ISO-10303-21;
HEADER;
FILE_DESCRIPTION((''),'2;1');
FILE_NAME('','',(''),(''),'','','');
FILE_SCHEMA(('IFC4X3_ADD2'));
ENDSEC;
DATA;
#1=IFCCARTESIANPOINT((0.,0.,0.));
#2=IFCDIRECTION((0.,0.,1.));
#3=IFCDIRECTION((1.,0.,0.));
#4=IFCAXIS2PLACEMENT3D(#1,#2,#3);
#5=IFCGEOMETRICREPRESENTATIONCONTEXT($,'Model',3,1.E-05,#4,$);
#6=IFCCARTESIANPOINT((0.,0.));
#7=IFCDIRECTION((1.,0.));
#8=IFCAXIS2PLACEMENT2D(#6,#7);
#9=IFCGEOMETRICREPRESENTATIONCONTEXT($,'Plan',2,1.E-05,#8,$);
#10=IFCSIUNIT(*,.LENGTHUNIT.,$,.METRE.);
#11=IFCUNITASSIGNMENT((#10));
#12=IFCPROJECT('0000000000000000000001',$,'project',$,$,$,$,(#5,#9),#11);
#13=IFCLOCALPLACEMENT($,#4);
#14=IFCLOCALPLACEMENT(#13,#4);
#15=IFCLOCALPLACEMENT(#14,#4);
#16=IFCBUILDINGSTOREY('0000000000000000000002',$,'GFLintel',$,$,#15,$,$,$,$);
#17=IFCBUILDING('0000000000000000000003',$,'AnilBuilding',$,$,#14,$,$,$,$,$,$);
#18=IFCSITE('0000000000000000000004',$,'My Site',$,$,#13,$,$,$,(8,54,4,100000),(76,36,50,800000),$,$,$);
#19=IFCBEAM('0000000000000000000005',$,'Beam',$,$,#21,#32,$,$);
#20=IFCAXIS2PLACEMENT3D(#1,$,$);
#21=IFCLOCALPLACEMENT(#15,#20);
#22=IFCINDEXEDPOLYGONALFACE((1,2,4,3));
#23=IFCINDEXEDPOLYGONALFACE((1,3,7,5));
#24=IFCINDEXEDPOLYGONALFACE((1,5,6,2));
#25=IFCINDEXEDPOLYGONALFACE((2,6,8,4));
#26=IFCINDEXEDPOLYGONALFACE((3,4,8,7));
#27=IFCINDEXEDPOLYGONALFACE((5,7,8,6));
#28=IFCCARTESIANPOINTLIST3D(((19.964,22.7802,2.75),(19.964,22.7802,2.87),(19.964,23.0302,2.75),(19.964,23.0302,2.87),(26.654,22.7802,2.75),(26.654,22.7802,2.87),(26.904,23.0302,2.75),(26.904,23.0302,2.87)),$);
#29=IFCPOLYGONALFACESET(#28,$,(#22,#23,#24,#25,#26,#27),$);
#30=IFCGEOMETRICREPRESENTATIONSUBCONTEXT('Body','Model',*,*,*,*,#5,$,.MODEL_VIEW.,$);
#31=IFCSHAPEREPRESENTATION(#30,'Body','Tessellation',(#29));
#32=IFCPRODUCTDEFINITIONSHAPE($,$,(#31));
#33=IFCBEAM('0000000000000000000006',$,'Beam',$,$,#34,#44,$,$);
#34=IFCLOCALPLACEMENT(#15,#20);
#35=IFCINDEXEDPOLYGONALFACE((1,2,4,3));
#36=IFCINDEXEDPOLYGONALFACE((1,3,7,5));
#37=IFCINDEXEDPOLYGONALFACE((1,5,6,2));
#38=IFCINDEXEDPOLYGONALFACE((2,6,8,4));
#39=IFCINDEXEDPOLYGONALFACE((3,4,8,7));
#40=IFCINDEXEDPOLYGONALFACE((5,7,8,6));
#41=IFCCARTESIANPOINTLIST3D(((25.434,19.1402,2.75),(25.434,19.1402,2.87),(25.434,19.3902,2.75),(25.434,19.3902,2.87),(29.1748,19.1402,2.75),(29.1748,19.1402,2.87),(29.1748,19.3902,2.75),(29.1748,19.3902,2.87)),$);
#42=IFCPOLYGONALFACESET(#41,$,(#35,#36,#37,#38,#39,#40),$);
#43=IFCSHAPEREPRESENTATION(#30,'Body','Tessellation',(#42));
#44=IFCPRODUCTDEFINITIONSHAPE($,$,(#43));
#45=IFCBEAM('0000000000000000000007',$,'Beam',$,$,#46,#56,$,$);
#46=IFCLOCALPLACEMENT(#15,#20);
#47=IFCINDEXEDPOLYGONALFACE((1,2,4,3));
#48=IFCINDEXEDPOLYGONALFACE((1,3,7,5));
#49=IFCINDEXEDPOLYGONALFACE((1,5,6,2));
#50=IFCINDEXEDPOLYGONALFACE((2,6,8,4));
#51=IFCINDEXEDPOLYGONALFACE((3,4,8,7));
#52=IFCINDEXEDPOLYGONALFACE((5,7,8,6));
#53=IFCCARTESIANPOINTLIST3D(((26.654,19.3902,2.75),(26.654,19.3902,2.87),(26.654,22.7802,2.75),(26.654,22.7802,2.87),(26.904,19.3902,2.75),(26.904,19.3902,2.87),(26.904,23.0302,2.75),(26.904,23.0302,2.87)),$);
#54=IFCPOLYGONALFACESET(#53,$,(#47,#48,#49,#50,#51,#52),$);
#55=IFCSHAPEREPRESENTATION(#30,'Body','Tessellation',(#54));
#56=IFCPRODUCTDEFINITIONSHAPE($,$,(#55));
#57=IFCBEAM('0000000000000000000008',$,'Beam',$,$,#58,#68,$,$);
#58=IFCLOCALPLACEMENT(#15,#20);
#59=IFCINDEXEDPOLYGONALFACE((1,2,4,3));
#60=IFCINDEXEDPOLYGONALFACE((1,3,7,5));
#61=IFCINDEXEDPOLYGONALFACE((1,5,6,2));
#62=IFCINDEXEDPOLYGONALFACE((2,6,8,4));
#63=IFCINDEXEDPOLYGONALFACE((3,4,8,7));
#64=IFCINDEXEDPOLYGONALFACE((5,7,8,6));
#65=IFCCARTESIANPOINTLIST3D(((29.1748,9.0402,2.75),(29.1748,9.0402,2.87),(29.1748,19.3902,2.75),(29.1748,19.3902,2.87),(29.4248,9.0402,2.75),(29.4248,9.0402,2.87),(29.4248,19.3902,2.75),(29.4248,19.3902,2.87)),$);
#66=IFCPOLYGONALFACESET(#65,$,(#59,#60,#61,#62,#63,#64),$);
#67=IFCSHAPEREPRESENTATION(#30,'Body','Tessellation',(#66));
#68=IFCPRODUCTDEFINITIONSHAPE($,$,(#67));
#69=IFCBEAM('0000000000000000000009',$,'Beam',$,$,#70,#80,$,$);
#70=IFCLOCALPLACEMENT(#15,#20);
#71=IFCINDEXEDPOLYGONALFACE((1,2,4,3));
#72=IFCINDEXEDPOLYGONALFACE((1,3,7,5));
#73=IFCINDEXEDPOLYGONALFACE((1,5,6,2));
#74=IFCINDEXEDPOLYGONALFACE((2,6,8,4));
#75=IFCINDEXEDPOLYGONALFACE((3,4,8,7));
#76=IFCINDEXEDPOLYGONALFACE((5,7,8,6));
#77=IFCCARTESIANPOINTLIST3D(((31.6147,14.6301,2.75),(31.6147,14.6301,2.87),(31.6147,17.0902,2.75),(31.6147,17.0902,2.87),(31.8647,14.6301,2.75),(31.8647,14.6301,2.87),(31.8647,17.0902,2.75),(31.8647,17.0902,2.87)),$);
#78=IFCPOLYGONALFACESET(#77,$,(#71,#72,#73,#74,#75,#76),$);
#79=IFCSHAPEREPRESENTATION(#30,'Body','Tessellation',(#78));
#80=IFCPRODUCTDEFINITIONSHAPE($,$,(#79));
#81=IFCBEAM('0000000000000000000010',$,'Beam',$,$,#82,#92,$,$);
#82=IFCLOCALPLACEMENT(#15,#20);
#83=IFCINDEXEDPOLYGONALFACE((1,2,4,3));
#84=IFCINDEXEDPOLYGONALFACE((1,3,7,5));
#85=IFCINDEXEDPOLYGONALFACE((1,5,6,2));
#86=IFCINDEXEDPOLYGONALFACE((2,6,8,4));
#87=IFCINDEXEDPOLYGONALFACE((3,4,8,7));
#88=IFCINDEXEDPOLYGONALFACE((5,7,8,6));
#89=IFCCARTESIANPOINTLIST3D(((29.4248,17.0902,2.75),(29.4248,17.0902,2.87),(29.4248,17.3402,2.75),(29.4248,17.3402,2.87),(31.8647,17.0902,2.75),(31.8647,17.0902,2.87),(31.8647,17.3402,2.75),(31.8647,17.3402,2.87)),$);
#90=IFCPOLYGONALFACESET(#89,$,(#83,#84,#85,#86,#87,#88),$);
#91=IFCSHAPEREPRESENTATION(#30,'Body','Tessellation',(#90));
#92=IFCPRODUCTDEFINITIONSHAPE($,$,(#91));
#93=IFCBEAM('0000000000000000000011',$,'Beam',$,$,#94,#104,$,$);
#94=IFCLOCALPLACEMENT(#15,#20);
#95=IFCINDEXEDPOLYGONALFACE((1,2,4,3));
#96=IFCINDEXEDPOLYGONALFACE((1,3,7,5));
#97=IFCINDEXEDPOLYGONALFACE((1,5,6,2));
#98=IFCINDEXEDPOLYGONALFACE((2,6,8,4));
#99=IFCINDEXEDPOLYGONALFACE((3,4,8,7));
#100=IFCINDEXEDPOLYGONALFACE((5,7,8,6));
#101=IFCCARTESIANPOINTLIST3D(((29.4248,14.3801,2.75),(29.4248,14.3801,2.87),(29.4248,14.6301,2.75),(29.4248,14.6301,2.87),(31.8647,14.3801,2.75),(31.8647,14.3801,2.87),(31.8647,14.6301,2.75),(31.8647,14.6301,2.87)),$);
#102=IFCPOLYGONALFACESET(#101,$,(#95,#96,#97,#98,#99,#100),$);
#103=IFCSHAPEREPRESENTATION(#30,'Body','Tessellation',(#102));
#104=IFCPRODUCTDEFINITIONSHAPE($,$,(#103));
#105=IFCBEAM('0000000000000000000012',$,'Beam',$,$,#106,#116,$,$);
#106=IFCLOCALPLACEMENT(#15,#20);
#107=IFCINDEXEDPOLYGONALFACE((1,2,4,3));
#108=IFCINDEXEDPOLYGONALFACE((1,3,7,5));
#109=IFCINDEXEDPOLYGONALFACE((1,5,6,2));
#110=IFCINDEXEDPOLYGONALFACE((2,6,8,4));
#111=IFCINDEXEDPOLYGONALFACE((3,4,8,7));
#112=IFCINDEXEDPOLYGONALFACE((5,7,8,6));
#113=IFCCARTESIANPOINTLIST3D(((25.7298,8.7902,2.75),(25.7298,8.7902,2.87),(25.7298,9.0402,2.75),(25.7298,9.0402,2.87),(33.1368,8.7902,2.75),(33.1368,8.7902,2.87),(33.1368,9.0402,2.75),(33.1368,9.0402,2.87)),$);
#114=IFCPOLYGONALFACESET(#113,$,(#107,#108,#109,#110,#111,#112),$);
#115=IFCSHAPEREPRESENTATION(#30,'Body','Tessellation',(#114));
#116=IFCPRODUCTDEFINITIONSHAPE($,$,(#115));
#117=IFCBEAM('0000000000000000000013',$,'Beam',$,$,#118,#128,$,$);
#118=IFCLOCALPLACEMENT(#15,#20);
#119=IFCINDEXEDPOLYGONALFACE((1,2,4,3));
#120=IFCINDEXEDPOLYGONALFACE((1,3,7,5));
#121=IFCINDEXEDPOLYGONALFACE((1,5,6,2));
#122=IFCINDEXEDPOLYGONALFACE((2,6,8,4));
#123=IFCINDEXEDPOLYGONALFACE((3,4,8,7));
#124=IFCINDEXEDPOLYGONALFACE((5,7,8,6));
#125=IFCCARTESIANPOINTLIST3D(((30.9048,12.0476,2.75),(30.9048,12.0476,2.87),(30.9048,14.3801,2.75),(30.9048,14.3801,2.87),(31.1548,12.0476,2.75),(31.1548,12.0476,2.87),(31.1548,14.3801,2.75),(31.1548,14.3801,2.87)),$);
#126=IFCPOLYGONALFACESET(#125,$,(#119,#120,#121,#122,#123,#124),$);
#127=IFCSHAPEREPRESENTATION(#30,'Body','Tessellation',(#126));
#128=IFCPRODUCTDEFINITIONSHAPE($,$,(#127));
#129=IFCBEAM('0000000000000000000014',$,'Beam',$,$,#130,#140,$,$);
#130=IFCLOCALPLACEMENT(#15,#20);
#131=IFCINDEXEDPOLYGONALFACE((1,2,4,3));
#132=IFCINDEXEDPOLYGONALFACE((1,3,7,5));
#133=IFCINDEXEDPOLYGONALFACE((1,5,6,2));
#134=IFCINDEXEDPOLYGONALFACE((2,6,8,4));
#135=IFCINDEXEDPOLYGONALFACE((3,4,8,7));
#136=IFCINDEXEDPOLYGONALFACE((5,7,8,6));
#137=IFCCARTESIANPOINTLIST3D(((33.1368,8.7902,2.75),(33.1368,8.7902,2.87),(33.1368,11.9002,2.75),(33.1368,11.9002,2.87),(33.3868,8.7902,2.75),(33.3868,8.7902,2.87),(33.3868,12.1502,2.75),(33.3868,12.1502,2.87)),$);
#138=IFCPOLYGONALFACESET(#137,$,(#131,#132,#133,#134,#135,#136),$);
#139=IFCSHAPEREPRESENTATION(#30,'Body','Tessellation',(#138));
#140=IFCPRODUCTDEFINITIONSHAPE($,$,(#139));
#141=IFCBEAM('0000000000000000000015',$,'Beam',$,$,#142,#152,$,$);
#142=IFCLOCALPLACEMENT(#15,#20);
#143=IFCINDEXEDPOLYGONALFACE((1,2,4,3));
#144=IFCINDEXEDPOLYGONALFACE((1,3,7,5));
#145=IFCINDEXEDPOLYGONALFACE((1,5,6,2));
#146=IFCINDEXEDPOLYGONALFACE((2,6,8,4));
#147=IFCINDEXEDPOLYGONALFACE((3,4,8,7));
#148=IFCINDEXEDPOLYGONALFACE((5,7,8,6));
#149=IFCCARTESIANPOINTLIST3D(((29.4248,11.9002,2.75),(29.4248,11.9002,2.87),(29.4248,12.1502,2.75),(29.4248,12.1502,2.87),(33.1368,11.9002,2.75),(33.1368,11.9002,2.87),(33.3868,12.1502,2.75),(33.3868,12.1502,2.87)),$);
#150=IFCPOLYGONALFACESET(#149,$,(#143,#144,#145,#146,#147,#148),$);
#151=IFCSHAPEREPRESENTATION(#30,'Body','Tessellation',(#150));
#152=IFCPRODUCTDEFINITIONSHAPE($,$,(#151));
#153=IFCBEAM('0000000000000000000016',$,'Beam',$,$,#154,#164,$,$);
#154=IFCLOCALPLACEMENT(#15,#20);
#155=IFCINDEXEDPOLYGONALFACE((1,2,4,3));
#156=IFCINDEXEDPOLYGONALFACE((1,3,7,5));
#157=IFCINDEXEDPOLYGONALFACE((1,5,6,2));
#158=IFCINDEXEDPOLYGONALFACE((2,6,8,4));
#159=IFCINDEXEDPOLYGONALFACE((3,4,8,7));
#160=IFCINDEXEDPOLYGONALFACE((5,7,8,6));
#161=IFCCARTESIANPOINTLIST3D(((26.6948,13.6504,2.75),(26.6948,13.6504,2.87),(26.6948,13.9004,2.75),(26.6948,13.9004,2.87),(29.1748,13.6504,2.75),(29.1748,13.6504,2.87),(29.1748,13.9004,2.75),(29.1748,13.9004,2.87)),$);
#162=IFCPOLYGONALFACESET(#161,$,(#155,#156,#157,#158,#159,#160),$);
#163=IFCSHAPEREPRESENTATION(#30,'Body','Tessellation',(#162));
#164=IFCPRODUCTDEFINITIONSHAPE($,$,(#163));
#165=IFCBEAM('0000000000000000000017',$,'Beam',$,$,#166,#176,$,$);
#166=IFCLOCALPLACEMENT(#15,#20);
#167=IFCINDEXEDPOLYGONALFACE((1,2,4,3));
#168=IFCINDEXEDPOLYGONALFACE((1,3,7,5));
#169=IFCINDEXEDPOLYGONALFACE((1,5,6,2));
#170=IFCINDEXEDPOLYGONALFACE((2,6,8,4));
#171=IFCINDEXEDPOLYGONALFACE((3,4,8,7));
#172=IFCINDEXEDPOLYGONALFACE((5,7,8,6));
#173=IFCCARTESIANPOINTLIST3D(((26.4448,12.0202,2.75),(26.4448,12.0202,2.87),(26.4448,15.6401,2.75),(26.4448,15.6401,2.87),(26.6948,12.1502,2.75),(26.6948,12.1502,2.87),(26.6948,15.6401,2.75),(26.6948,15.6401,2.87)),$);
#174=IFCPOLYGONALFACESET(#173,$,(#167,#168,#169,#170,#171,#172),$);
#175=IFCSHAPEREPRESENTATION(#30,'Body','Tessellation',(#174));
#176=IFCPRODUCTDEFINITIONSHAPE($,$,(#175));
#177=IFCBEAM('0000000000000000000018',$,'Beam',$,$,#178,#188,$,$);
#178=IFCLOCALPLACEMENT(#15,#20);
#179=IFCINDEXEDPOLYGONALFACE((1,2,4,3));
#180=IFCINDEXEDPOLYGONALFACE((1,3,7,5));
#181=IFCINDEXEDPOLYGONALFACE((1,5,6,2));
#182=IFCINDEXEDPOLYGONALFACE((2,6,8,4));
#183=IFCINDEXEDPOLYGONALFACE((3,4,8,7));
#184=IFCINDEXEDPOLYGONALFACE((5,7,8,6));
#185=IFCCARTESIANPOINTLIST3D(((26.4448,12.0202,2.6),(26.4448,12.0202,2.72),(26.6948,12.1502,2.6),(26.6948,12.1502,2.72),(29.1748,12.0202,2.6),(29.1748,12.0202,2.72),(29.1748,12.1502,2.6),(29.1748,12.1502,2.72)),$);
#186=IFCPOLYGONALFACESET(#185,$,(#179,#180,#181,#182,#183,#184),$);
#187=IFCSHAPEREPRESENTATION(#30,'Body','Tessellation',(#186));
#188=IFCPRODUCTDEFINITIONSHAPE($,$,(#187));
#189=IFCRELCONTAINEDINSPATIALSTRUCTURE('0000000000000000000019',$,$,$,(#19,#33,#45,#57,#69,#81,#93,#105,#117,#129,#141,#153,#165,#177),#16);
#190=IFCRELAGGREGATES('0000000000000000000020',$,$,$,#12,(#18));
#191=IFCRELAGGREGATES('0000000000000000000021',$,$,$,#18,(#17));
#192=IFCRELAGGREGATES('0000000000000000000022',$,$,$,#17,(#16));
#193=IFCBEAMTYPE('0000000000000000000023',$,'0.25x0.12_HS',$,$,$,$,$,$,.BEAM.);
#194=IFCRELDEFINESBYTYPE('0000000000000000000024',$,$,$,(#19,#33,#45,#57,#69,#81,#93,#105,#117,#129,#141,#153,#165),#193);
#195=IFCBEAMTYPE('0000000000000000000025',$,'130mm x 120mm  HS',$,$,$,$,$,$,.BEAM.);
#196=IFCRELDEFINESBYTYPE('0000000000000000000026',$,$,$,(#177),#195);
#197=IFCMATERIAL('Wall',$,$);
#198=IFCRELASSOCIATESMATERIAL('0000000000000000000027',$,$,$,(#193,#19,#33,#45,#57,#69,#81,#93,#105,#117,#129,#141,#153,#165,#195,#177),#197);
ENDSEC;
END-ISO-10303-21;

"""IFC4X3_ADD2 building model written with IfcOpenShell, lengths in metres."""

from ifc_helpers import new_model, si_unit, frame, origin_with_axes, origin_2d_with_axis, place, context, subcontext, project, spatial, rectangle, extrude, clip, halfspace, material, material_profile, profile_set, profile_usage, type_object, element, save


model = new_model("IFC4X3_ADD2")

# Units and contexts
model_context = context("Model", 3, precision=1e-05, world=origin_with_axes())
plan_context = context("Plan", 2, precision=1e-05, world=origin_2d_with_axis())
body_context = subcontext(model_context, "Body", "Model", "MODEL_VIEW")
ifc_project = project(units=[si_unit("LENGTHUNIT", "METRE")], contexts=[model_context, plan_context])

# Site, building, storey
site_placement = place(None, origin_with_axes())
site = spatial("IfcSite", under=ifc_project, at=site_placement, Name="My Site", RefLatitude=(8, 54, 4, 100000), RefLongitude=(76, 36, 50, 800000))
building_placement = place(site_placement, origin_with_axes())
building = spatial("IfcBuilding", under=site, at=building_placement, Name="AnilBuilding")
storey_placement = place(building_placement, origin_with_axes())
storey = spatial("IfcBuildingStorey", under=building, at=storey_placement, Name="GFLintel")

# Beams
ifc_material_1 = material(Name="Wall")
ifc_material_profile_1 = material_profile(ifc_material_1, rectangle(XDim=0.25, YDim=0.12))
ifc_profile_set_1 = profile_set([ifc_material_profile_1], Name="concrete")
ifc_profile_usage_1 = profile_usage(ifc_profile_set_1)
beam_type_1 = type_object("IfcBeamType", Name="0.25x0.12_HS", PredefinedType="BEAM", material=ifc_profile_set_1)
beam_1_placement = place(storey_placement, frame((26.904, 22.9052, 2.81), z_axis=(-1.0, 0.0, 0.0), x_axis=(0.0, -1.0, 0.0)))
element("IfcBeam", 1, at=beam_1_placement, inside=storey, type_object=beam_type_1, material=ifc_profile_usage_1, Name="Beam", context=body_context, shape_type="Clipping", body=[
    clip(extrude(rectangle(XDim=0.25, YDim=0.12), origin_with_axes(), (0.0, 0.0, 1.0), 6.94), halfspace(frame((-0.125, -2.66, 0.0), z_axis=(0.707106, 0.0, -0.707107), x_axis=(0.0, -1.0, 0.0)), False)),
])
ifc_profile_usage_2 = profile_usage(ifc_profile_set_1)
beam_2_placement = place(storey_placement, frame((29.1748, 19.2652, 2.81), z_axis=(-1.0, 0.000001, 0.0), x_axis=(-0.000001, -1.0, 0.0)))
element("IfcBeam", 2, at=beam_2_placement, inside=storey, type_object=beam_type_1, material=ifc_profile_usage_2, Name="Beam", context=body_context, shape_type="SweptSolid", body=[
    extrude(rectangle(XDim=0.25, YDim=0.12), origin_with_axes(), (0.0, 0.0, 1.0), 3.7408),
])
ifc_profile_usage_3 = profile_usage(ifc_profile_set_1)
beam_3_placement = place(storey_placement, frame((26.779, 23.0302, 2.81), z_axis=(0.0, -1.0, 0.0), x_axis=(1.0, 0.0, 0.0)))
element("IfcBeam", 3, at=beam_3_placement, inside=storey, type_object=beam_type_1, material=ifc_profile_usage_3, Name="Beam", context=body_context, shape_type="Clipping", body=[
    clip(extrude(rectangle(XDim=0.25, YDim=0.12), origin_with_axes(), (0.0, 0.0, 1.0), 3.64), halfspace(frame((0.125, -2.66, 0.0), z_axis=(-0.707107, 0.0, -0.707107), x_axis=(0.0, 1.0, 0.0)), False)),
])
ifc_profile_usage_4 = profile_usage(ifc_profile_set_1)
beam_4_placement = place(storey_placement, frame((29.2998, 19.3902, 2.81), z_axis=(0.0, -1.0, 0.0), x_axis=(1.0, 0.0, 0.0)))
element("IfcBeam", 4, at=beam_4_placement, inside=storey, type_object=beam_type_1, material=ifc_profile_usage_4, Name="Beam", context=body_context, shape_type="SweptSolid", body=[
    extrude(rectangle(XDim=0.25, YDim=0.12), origin_with_axes(), (0.0, 0.0, 1.0), 10.35),
])
ifc_profile_usage_5 = profile_usage(ifc_profile_set_1)
beam_5_placement = place(storey_placement, frame((31.7397, 17.0902, 2.81), z_axis=(0.0, -1.0, 0.0), x_axis=(1.0, 0.0, 0.0)))
element("IfcBeam", 5, at=beam_5_placement, inside=storey, type_object=beam_type_1, material=ifc_profile_usage_5, Name="Beam", context=body_context, shape_type="SweptSolid", body=[
    extrude(rectangle(XDim=0.25, YDim=0.12), origin_with_axes(), (0.0, 0.0, 1.0), 2.46),
])
ifc_profile_usage_6 = profile_usage(ifc_profile_set_1)
beam_6_placement = place(storey_placement, frame((31.8647, 17.2152, 2.81), z_axis=(-1.0, 0.000001, 0.0), x_axis=(-0.000001, -1.0, 0.0)))
element("IfcBeam", 6, at=beam_6_placement, inside=storey, type_object=beam_type_1, material=ifc_profile_usage_6, Name="Beam", context=body_context, shape_type="SweptSolid", body=[
    extrude(rectangle(XDim=0.25, YDim=0.12), origin_with_axes(), (0.0, 0.0, 1.0), 2.44),
])
ifc_profile_usage_7 = profile_usage(ifc_profile_set_1)
beam_7_placement = place(storey_placement, frame((31.8647, 14.5051, 2.81), z_axis=(-1.0, 0.000001, 0.0), x_axis=(-0.000001, -1.0, 0.0)))
element("IfcBeam", 7, at=beam_7_placement, inside=storey, type_object=beam_type_1, material=ifc_profile_usage_7, Name="Beam", context=body_context, shape_type="SweptSolid", body=[
    extrude(rectangle(XDim=0.25, YDim=0.12), origin_with_axes(), (0.0, 0.0, 1.0), 2.44),
])
ifc_profile_usage_8 = profile_usage(ifc_profile_set_1)
beam_8_placement = place(storey_placement, frame((33.1368, 8.9152, 2.81), z_axis=(-1.0, 0.0, 0.0), x_axis=(0.0, -1.0, 0.0)))
element("IfcBeam", 8, at=beam_8_placement, inside=storey, type_object=beam_type_1, material=ifc_profile_usage_8, Name="Beam", context=body_context, shape_type="SweptSolid", body=[
    extrude(rectangle(XDim=0.25, YDim=0.12), origin_with_axes(), (0.0, 0.0, 1.0), 7.407),
])
ifc_profile_usage_9 = profile_usage(ifc_profile_set_1)
beam_9_placement = place(storey_placement, frame((31.0298, 14.3801, 2.81), z_axis=(0.0, -1.0, 0.0), x_axis=(1.0, 0.0, 0.0)))
element("IfcBeam", 9, at=beam_9_placement, inside=storey, type_object=beam_type_1, material=ifc_profile_usage_9, Name="Beam", context=body_context, shape_type="SweptSolid", body=[
    extrude(rectangle(XDim=0.25, YDim=0.12), origin_with_axes(), (0.0, 0.0, 1.0), 2.3325),
])
ifc_profile_usage_10 = profile_usage(ifc_profile_set_1)
beam_10_placement = place(storey_placement, frame((33.2618, 12.1502, 2.81), z_axis=(0.0, -1.0, 0.0), x_axis=(1.0, 0.0, 0.0)))
element("IfcBeam", 10, at=beam_10_placement, inside=storey, type_object=beam_type_1, material=ifc_profile_usage_10, Name="Beam", context=body_context, shape_type="Clipping", body=[
    clip(extrude(rectangle(XDim=0.25, YDim=0.12), origin_with_axes(), (0.0, 0.0, 1.0), 3.36), halfspace(frame((0.125, -2.66, 0.0), z_axis=(-0.707107, 0.0, -0.707107), x_axis=(0.0, 1.0, 0.0)), False)),
])
ifc_profile_usage_11 = profile_usage(ifc_profile_set_1)
beam_11_placement = place(storey_placement, frame((33.3868, 12.0252, 2.81), z_axis=(-1.0, 0.000001, 0.0), x_axis=(-0.000001, -1.0, 0.0)))
element("IfcBeam", 11, at=beam_11_placement, inside=storey, type_object=beam_type_1, material=ifc_profile_usage_11, Name="Beam", context=body_context, shape_type="Clipping", body=[
    clip(extrude(rectangle(XDim=0.25, YDim=0.12), origin_with_axes(), (0.0, 0.0, 1.0), 3.962), halfspace(frame((-0.125, -2.685, 0.0), z_axis=(0.707106, 0.0, -0.707107), x_axis=(0.0, -1.0, 0.0)), False)),
])
ifc_profile_usage_12 = profile_usage(ifc_profile_set_1)
beam_12_placement = place(storey_placement, frame((29.1748, 13.7754, 2.81), z_axis=(-1.0, 0.000001, 0.0), x_axis=(-0.000001, -1.0, 0.0)))
element("IfcBeam", 12, at=beam_12_placement, inside=storey, type_object=beam_type_1, material=ifc_profile_usage_12, Name="Beam", context=body_context, shape_type="SweptSolid", body=[
    extrude(rectangle(XDim=0.25, YDim=0.12), origin_with_axes(), (0.0, 0.0, 1.0), 2.48),
])
ifc_profile_usage_13 = profile_usage(ifc_profile_set_1)
beam_13_placement = place(storey_placement, frame((26.5698, 15.6401, 2.81), z_axis=(0.0, -1.0, 0.0), x_axis=(1.0, 0.0, 0.0)))
element("IfcBeam", 13, at=beam_13_placement, inside=storey, type_object=beam_type_1, material=ifc_profile_usage_13, Name="Beam", context=body_context, shape_type="Clipping", body=[
    clip(extrude(rectangle(XDim=0.25, YDim=0.12), origin_with_axes(), (0.0, 0.0, 1.0), 3.6199), halfspace(frame((-0.125, -2.81, 3.6199), z_axis=(0.461351, 0.0, 0.887218), x_axis=(0.000001, -1.0, 0.0)), False)),
])
ifc_material_profile_2 = material_profile(ifc_material_1, rectangle(XDim=0.13, YDim=0.12))
ifc_profile_set_2 = profile_set([ifc_material_profile_2], Name="concrete")
ifc_profile_usage_14 = profile_usage(ifc_profile_set_2)
beam_type_2 = type_object("IfcBeamType", Name="130mm x 120mm  HS", PredefinedType="BEAM", material=ifc_profile_set_2)
beam_14_placement = place(storey_placement, frame((29.1748, 12.0852, 2.66), z_axis=(-1.0, 0.0, 0.0), x_axis=(0.0, -1.0, 0.0)))
element("IfcBeam", 14, at=beam_14_placement, inside=storey, type_object=beam_type_2, material=ifc_profile_usage_14, Name="Beam", context=body_context, shape_type="Clipping", body=[
    clip(extrude(rectangle(XDim=0.13, YDim=0.12), origin_with_axes(), (0.0, 0.0, 1.0), 2.73), halfspace(frame((0.065, -2.66, 2.73), z_axis=(-0.887218, 0.0, 0.461351), x_axis=(0.0, 1.0, 0.0)), False)),
])

save(model, "model.ifc")
